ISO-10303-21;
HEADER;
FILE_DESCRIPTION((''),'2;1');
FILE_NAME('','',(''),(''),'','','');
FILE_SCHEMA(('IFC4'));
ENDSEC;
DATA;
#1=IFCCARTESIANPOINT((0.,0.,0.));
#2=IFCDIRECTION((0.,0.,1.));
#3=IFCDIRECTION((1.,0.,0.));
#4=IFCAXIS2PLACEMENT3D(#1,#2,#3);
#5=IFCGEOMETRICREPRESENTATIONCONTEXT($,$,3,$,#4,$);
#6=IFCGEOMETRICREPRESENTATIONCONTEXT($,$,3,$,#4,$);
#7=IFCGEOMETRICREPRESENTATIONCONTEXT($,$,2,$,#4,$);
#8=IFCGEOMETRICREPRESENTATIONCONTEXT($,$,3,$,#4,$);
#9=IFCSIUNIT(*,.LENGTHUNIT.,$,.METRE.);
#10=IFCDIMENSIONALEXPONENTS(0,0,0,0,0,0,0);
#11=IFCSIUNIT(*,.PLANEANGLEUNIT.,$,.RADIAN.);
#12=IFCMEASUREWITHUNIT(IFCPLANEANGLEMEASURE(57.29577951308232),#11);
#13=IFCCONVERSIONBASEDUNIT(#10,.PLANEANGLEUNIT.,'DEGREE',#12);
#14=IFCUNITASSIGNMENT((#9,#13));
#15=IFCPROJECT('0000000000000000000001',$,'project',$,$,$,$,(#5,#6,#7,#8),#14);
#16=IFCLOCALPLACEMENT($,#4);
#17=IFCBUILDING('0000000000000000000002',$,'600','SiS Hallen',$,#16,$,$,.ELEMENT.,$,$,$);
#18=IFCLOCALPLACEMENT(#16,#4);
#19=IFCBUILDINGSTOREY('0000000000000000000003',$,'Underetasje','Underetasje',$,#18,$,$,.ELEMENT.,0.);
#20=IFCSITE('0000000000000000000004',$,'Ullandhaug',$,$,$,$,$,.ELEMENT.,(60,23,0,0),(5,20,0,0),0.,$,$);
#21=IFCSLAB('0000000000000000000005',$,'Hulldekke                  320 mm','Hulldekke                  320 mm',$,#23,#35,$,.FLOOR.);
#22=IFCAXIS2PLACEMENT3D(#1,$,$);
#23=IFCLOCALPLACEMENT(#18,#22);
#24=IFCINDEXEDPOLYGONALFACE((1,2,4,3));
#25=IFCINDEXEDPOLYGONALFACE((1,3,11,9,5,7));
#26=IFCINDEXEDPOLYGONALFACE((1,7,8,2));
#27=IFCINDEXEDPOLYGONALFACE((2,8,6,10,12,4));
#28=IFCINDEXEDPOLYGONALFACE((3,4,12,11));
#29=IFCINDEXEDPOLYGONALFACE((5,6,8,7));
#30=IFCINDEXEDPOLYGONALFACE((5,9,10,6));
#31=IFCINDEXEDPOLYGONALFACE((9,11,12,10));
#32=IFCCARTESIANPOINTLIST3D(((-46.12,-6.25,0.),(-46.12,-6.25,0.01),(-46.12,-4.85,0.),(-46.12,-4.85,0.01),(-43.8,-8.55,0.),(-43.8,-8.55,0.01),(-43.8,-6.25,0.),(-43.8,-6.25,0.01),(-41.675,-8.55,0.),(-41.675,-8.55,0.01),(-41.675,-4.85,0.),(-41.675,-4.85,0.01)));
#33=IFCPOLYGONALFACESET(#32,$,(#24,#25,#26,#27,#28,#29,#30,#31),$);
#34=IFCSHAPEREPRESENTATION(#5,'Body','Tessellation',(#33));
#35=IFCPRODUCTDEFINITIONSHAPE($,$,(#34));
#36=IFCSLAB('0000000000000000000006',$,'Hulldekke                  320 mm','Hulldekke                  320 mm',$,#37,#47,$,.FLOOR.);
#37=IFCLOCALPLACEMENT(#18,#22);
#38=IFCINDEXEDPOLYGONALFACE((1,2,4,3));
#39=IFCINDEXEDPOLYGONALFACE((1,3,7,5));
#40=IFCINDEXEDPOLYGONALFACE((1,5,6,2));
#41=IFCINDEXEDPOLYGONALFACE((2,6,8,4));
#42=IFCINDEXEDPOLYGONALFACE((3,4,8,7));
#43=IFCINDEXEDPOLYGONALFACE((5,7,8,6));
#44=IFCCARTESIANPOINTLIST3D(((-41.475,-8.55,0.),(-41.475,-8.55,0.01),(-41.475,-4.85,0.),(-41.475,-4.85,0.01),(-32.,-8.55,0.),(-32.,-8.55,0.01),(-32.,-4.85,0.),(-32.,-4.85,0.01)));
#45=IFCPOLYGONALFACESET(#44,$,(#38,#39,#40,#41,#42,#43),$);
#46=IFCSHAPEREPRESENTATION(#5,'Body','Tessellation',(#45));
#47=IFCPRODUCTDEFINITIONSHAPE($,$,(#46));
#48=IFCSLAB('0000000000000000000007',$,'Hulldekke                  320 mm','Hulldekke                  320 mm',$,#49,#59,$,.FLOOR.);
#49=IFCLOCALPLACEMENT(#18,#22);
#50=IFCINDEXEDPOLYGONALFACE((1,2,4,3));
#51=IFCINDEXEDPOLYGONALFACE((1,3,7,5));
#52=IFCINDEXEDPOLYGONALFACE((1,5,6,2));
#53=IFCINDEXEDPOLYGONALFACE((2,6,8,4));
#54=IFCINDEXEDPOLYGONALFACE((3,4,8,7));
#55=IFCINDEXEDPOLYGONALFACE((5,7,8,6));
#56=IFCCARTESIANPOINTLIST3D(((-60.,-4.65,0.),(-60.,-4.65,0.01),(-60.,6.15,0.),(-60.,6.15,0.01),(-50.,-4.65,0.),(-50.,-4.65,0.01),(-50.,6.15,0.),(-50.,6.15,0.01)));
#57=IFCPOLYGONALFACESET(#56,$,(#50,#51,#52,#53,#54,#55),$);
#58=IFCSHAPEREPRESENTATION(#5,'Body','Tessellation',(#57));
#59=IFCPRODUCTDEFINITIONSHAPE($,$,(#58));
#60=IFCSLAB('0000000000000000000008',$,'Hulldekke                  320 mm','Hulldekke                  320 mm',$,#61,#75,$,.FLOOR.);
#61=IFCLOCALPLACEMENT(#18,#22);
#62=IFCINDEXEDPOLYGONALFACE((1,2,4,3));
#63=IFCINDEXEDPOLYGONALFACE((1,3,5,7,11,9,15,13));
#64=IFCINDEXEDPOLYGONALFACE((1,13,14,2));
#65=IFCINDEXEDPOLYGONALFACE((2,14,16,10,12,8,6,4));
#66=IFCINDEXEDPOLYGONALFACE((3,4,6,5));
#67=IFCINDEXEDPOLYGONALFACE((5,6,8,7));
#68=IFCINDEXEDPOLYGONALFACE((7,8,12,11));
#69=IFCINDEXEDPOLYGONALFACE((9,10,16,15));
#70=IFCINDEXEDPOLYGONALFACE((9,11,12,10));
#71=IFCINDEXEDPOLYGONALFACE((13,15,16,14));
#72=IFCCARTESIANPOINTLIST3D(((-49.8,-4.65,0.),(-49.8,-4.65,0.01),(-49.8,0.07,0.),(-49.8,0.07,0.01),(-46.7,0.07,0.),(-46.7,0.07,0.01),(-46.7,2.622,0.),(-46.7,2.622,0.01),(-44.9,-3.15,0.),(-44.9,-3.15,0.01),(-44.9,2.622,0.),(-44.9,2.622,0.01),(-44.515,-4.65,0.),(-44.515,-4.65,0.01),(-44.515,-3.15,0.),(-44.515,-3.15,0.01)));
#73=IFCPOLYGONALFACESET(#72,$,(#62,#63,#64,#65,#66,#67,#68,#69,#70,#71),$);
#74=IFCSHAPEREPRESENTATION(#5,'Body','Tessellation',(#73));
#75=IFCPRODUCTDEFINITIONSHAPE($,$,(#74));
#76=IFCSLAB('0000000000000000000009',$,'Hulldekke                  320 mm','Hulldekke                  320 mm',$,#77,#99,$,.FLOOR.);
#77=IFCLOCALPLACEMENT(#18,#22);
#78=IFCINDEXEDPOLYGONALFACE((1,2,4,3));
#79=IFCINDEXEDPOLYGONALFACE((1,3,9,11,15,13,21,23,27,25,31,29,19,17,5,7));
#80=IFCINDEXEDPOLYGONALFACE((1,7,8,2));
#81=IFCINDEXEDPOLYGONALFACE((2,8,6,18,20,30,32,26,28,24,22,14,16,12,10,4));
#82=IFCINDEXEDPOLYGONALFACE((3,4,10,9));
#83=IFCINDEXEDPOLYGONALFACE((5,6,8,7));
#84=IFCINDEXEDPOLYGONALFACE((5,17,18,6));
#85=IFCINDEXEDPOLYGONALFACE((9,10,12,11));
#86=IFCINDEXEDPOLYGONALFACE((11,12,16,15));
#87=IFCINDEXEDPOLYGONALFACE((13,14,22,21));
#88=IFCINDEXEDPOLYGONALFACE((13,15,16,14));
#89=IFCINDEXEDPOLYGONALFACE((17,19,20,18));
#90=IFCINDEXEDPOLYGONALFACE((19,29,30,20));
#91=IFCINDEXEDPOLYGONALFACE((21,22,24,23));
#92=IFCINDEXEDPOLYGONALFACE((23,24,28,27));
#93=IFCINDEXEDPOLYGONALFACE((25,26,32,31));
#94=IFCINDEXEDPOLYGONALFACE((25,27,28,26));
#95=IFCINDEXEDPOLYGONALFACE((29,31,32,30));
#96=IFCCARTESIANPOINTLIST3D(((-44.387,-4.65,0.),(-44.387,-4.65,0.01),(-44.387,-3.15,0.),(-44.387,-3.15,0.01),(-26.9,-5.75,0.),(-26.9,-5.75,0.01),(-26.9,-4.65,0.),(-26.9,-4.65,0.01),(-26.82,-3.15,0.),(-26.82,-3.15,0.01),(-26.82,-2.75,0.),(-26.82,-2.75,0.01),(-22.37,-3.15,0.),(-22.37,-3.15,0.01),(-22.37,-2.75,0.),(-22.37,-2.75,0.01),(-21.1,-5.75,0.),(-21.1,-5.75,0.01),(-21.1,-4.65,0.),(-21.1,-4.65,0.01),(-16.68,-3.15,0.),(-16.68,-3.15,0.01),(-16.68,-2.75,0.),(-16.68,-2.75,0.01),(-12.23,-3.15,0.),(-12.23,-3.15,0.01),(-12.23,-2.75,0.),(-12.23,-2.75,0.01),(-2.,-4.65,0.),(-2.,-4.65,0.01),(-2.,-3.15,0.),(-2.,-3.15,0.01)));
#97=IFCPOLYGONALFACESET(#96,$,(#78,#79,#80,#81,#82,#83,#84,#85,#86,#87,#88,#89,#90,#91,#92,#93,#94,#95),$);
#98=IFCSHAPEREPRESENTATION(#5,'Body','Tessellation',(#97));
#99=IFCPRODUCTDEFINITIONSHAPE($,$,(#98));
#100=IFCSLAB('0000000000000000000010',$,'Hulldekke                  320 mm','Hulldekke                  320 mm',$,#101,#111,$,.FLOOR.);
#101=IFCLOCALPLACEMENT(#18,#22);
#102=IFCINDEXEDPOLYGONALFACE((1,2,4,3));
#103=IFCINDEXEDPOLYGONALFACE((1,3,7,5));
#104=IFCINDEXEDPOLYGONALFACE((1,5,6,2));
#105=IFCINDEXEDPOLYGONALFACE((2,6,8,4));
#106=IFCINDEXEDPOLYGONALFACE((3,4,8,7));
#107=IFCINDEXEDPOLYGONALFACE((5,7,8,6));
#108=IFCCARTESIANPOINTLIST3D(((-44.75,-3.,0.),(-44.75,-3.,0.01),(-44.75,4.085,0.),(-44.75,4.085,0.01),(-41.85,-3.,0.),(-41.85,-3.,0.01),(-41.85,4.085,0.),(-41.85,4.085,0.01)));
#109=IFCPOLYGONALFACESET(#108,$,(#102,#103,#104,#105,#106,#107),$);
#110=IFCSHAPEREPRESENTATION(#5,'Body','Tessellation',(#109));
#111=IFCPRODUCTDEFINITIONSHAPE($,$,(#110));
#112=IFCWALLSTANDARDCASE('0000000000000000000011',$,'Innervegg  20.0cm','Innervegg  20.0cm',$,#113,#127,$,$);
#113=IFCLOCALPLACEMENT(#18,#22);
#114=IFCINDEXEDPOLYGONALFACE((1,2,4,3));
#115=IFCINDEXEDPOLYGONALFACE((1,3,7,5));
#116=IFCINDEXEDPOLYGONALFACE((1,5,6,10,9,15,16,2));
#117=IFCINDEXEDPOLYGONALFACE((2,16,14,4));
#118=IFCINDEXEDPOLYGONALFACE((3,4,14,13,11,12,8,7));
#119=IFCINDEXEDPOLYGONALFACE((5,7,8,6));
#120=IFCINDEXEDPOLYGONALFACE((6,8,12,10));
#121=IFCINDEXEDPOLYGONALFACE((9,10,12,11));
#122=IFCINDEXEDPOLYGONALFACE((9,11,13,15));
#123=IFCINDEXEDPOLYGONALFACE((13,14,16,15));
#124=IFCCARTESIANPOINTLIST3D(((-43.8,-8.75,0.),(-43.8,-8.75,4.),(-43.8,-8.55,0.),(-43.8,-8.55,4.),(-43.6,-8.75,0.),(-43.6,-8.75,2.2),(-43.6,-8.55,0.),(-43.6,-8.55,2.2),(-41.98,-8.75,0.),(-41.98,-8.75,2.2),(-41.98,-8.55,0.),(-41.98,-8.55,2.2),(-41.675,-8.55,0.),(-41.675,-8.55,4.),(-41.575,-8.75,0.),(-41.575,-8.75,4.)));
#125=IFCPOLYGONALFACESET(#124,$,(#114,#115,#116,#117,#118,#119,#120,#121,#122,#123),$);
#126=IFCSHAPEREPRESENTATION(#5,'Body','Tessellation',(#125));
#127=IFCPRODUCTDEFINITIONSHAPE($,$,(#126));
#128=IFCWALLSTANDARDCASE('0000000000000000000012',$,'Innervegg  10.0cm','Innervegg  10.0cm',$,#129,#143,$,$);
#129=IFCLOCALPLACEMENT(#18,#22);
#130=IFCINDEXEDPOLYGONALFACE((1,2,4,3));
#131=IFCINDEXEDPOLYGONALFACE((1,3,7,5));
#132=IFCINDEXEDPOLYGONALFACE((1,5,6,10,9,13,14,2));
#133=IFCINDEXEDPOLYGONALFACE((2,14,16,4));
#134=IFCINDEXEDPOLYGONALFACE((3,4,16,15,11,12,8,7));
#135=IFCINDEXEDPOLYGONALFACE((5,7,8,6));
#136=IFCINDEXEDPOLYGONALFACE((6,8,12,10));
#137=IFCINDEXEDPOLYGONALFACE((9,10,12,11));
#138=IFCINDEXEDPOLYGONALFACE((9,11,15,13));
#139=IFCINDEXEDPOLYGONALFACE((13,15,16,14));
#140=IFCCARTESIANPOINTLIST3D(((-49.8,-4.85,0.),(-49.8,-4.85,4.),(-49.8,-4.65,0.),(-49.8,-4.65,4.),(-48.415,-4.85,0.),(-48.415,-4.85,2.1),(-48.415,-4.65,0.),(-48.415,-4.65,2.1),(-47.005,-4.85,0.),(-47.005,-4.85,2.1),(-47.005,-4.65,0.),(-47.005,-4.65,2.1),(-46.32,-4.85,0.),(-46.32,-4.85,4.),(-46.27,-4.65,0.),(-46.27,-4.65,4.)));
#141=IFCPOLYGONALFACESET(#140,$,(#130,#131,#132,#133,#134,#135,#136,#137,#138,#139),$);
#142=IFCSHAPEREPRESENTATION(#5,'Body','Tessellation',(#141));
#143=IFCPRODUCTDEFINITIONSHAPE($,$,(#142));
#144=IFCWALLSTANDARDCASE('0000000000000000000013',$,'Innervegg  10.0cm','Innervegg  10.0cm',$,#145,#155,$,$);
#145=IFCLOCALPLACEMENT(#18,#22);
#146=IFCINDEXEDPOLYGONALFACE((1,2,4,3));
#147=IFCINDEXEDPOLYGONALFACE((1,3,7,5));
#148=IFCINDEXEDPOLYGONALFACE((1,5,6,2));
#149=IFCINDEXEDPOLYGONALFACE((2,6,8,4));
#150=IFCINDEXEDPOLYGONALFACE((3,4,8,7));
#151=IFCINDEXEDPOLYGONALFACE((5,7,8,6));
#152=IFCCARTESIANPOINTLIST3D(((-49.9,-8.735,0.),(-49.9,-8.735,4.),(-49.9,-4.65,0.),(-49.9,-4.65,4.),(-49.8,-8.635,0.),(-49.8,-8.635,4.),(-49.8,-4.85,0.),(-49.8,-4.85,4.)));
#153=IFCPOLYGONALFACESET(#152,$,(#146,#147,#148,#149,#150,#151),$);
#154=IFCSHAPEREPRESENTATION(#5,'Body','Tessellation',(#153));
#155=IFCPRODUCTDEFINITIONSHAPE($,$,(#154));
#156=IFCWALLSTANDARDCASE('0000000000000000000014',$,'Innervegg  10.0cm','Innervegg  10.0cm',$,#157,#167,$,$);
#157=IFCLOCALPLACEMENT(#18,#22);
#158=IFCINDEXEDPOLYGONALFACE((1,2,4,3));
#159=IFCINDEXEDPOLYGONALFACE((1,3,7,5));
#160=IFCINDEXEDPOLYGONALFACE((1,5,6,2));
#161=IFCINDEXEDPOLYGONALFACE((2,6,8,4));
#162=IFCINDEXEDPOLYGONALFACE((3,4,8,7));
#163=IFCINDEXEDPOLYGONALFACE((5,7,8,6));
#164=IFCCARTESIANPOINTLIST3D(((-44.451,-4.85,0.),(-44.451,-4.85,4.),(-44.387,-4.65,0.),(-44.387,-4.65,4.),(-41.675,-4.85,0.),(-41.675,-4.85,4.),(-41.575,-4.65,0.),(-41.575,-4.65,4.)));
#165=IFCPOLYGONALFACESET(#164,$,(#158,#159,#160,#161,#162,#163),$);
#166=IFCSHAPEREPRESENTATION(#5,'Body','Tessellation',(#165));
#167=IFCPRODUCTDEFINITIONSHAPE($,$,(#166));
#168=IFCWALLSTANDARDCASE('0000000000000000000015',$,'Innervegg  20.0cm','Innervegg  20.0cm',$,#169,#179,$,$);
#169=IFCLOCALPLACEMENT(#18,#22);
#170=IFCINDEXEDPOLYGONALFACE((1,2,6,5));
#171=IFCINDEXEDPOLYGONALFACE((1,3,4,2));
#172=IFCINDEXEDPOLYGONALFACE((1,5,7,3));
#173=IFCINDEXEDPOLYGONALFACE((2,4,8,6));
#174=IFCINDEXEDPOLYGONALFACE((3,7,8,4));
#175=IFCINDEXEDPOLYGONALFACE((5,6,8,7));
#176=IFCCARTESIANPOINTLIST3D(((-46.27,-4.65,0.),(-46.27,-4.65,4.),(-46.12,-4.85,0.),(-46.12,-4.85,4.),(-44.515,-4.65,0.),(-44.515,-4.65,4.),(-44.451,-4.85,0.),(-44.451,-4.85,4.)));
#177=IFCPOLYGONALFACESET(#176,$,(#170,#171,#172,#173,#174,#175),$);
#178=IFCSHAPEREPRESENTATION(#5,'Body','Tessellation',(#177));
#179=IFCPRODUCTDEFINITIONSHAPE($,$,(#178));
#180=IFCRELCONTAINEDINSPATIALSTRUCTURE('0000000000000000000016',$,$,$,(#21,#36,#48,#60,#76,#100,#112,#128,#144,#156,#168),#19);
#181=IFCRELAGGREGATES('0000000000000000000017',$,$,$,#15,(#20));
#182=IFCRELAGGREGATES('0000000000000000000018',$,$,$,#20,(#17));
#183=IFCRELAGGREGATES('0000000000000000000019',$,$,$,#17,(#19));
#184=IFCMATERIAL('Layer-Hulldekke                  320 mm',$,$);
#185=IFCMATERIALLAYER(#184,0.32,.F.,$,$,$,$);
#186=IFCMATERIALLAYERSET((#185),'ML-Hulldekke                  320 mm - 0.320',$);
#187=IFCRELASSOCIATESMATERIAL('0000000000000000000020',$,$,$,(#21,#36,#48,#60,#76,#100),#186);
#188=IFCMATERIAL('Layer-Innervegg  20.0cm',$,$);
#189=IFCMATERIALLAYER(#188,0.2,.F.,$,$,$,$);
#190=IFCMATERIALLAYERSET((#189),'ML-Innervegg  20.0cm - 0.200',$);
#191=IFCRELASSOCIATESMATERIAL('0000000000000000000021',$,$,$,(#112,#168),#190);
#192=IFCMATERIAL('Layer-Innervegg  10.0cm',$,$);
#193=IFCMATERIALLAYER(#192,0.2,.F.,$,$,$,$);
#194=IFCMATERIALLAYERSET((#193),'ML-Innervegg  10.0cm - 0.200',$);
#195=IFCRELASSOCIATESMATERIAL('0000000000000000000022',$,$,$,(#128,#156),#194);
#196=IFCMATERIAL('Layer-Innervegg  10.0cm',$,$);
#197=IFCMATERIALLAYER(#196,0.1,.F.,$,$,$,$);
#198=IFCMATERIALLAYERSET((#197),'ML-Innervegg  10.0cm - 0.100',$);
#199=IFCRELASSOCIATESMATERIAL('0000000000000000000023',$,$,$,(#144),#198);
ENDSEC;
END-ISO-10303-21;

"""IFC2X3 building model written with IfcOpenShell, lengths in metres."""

from ifc_helpers import new_model, entity, si_unit, converted_unit, frame, origin_with_axes, place, context, project, spatial, polyline, outline, extrude, material, layer, layer_set, layer_usage, element, save


model = new_model("IFC2X3")

# Units and contexts
context_of_model_1 = context(None, 3, world=origin_with_axes())
context_of_model_2 = context(None, 3, world=origin_with_axes())
context_of_model_3 = context(None, 2, world=origin_with_axes())
context_of_model_4 = context(None, 3, world=origin_with_axes())
ifc_project = project(units=[si_unit("LENGTHUNIT", "METRE"), converted_unit("PLANEANGLEUNIT", "DEGREE", entity("IfcPlaneAngleMeasure", 57.29577951308232), si_unit("PLANEANGLEUNIT", "RADIAN"), dimensions=[0, 0, 0, 0, 0, 0, 0])], contexts=[context_of_model_1, context_of_model_2, context_of_model_3, context_of_model_4])

# Site, building, storey
site = spatial("IfcSite", under=ifc_project, Name="Ullandhaug", CompositionType="ELEMENT", RefLatitude=(60, 23, 0, 0), RefLongitude=(5, 20, 0, 0), RefElevation=0.0)
building_placement = place(None, origin_with_axes())
building = spatial("IfcBuilding", under=site, at=building_placement, Name="600", Description="SiS Hallen", CompositionType="ELEMENT")
storey_placement = place(building_placement, origin_with_axes())
storey = spatial("IfcBuildingStorey", under=building, at=storey_placement, Name="Underetasje", Description="Underetasje", CompositionType="ELEMENT", Elevation=0.0)

# Slabs
ifc_material_1 = material(Name="Layer-Hulldekke                  320 mm")
ifc_layer_1 = layer(ifc_material_1, 0.32, ventilated=False)
ifc_layer_set_1 = layer_set([ifc_layer_1], Name="ML-Hulldekke                  320 mm - 0.320")
ifc_layer_usage_1 = layer_usage(ifc_layer_set_1, "AXIS2", "POSITIVE", 0.0)
slab_1_placement = place(storey_placement, frame((-43.8, -8.55, 0.0), z_axis=(0.0, 0.0, 1.0), x_axis=(1.0, 0.0, 0.0)))
element("IfcSlab", 1, at=slab_1_placement, inside=storey, material=ifc_layer_usage_1, Name="Hulldekke                  320 mm", Description="Hulldekke                  320 mm", PredefinedType="FLOOR", context=context_of_model_1, shape_type="SweptSolid", body=[
    extrude(outline(polyline([(0.0, 0.0), (2.125, 0.0), (2.125, 3.7), (-2.32, 3.7), (-2.32, 2.3), (0.0, 2.3), (0.0, 0.0)])), origin_with_axes(), (0.0, 0.0, 1.0), 0.01),
])
slab_2_placement = place(storey_placement, frame((-41.475, -8.55, 0.0), z_axis=(0.0, 0.0, 1.0), x_axis=(1.0, 0.0, 0.0)))
element("IfcSlab", 2, at=slab_2_placement, inside=storey, material=ifc_layer_usage_1, Name="Hulldekke                  320 mm", Description="Hulldekke                  320 mm", PredefinedType="FLOOR", context=context_of_model_1, shape_type="SweptSolid", body=[
    extrude(outline(polyline([(0.0, 0.0), (9.475, 0.0), (9.475, 3.7), (0.0, 3.7), (0.0, 0.0)])), origin_with_axes(), (0.0, 0.0, 1.0), 0.01),
])
slab_3_placement = place(storey_placement, frame((-60.0, -4.65, 0.0), z_axis=(0.0, 0.0, 1.0), x_axis=(1.0, 0.0, 0.0)))
element("IfcSlab", 3, at=slab_3_placement, inside=storey, material=ifc_layer_usage_1, Name="Hulldekke                  320 mm", Description="Hulldekke                  320 mm", PredefinedType="FLOOR", context=context_of_model_1, shape_type="SweptSolid", body=[
    extrude(outline(polyline([(0.0, 0.0), (10.0, 0.0), (10.0, 10.8), (0.0, 10.8), (0.0, 0.0)])), origin_with_axes(), (0.0, 0.0, 1.0), 0.01),
])
slab_4_placement = place(storey_placement, frame((-49.8, -4.65, 0.0), z_axis=(0.0, 0.0, 1.0), x_axis=(1.0, 0.0, 0.0)))
element("IfcSlab", 4, at=slab_4_placement, inside=storey, material=ifc_layer_usage_1, Name="Hulldekke                  320 mm", Description="Hulldekke                  320 mm", PredefinedType="FLOOR", context=context_of_model_1, shape_type="SweptSolid", body=[
    extrude(outline(polyline([(0.0, 0.0), (5.285, 0.0), (5.285, 1.5), (4.9, 1.5), (4.9, 7.272), (3.1, 7.272), (3.1, 4.72), (0.0, 4.72), (0.0, 0.0)])), origin_with_axes(), (0.0, 0.0, 1.0), 0.01),
])
slab_5_placement = place(storey_placement, frame((-44.387, -4.65, 0.0), z_axis=(0.0, 0.0, 1.0), x_axis=(1.0, 0.0, 0.0)))
element("IfcSlab", 5, at=slab_5_placement, inside=storey, material=ifc_layer_usage_1, Name="Hulldekke                  320 mm", Description="Hulldekke                  320 mm", PredefinedType="FLOOR", context=context_of_model_1, shape_type="SweptSolid", body=[
    extrude(outline(polyline([(0.0, 0.0), (17.487, 0.0), (17.487, 1.1), (23.287, 1.1), (23.287, 0.0), (42.387, 0.0), (42.387, -1.5), (32.157, -1.5), (32.157, -1.9), (27.707, -1.9), (27.707, -1.5), (22.017, -1.5), (22.017, -1.9), (17.567, -1.9), (17.567, -1.5), (0.0, -1.5), (0.0, 0.0)])), frame((0.0, 0.0, 0.0), z_axis=(0.0, 0.0, -1.0), x_axis=(1.0, 0.0, 0.0)), (0.0, 0.0, -1.0), 0.01),
])
slab_6_placement = place(storey_placement, frame((-44.75, -3.0, 0.0), z_axis=(0.0, 0.0, 1.0), x_axis=(1.0, 0.0, 0.0)))
element("IfcSlab", 6, at=slab_6_placement, inside=storey, material=ifc_layer_usage_1, Name="Hulldekke                  320 mm", Description="Hulldekke                  320 mm", PredefinedType="FLOOR", context=context_of_model_1, shape_type="SweptSolid", body=[
    extrude(outline(polyline([(0.0, 0.0), (2.9, 0.0), (2.9, 7.085), (0.0, 7.085), (0.0, 0.0)])), origin_with_axes(), (0.0, 0.0, 1.0), 0.01),
])

# Walls, openings
ifc_material_2 = material(Name="Layer-Innervegg  20.0cm")
ifc_layer_2 = layer(ifc_material_2, 0.2, ventilated=False)
ifc_layer_set_2 = layer_set([ifc_layer_2], Name="ML-Innervegg  20.0cm - 0.200")
ifc_layer_usage_2 = layer_usage(ifc_layer_set_2, "AXIS2", "POSITIVE", 0.0)
wall_1_placement = place(storey_placement, frame((-41.675, -8.55, 0.0), z_axis=(0.0, 0.0, 1.0), x_axis=(-1.0, 0.0, 0.0)))
wall_1 = element("IfcWallStandardCase", 7, at=wall_1_placement, inside=storey, material=ifc_layer_usage_2, Name="Innervegg  20.0cm", Description="Innervegg  20.0cm", context=context_of_model_1, shape_type="SweptSolid", body=[
    extrude(outline(polyline([(0.0, 0.0), (2.125, 0.0), (2.125, 0.2), (-0.1, 0.2), (0.0, 0.0)])), frame((0.0, 0.0, 0.0), z_axis=(0.0, 0.0, 1.0), x_axis=(1.0, 0.0, 0.0)), (0.0, 0.0, 1.0), 4.0),
])
opening_1_placement = place(wall_1_placement, frame((0.305, 0.2, 0.0), z_axis=(0.0, 0.0, 1.0), x_axis=(1.0, 0.0, 0.0)))
element("IfcOpeningElement", 8, at=opening_1_placement, cuts=wall_1, context=context_of_model_1, shape_type="SweptSolid", body=[
    extrude(outline(polyline([(0.0, 0.0), (2.2, 0.0), (2.2, 1.62), (0.0, 1.62), (0.0, 0.0)])), frame((0.0, 0.0, 0.0), z_axis=(0.0, 1.0, 0.0), x_axis=(0.0, 0.0, 1.0)), (0.0, 0.0, -1.0), 0.2),
])
ifc_material_3 = material(Name="Layer-Innervegg  10.0cm")
ifc_layer_3 = layer(ifc_material_3, 0.2, ventilated=False)
ifc_layer_set_3 = layer_set([ifc_layer_3], Name="ML-Innervegg  10.0cm - 0.200")
ifc_layer_usage_3 = layer_usage(ifc_layer_set_3, "AXIS2", "POSITIVE", 0.0)
wall_2_placement = place(storey_placement, frame((-46.27, -4.65, 0.0), z_axis=(0.0, 0.0, 1.0), x_axis=(-1.0, 0.0, 0.0)))
wall_2 = element("IfcWallStandardCase", 9, at=wall_2_placement, inside=storey, material=ifc_layer_usage_3, Name="Innervegg  10.0cm", Description="Innervegg  10.0cm", context=context_of_model_1, shape_type="SweptSolid", body=[
    extrude(outline(polyline([(0.0, 0.0), (3.53, 0.0), (3.53, 0.2), (0.05, 0.2), (0.0, 0.0)])), frame((0.0, 0.0, 0.0), z_axis=(0.0, 0.0, 1.0), x_axis=(1.0, 0.0, 0.0)), (0.0, 0.0, 1.0), 4.0),
])
opening_2_placement = place(wall_2_placement, frame((0.735, 0.2, 0.0), z_axis=(0.0, 0.0, 1.0), x_axis=(1.0, 0.0, 0.0)))
element("IfcOpeningElement", 10, at=opening_2_placement, cuts=wall_2, context=context_of_model_1, shape_type="SweptSolid", body=[
    extrude(outline(polyline([(0.0, 0.0), (2.1, 0.0), (2.1, 1.41), (0.0, 1.41), (0.0, 0.0)])), frame((0.0, 0.0, 0.0), z_axis=(0.0, 1.0, 0.0), x_axis=(0.0, 0.0, 1.0)), (0.0, 0.0, -1.0), 0.2),
])

# Walls
ifc_material_4 = material(Name="Layer-Innervegg  10.0cm")
ifc_layer_4 = layer(ifc_material_4, 0.1, ventilated=False)
ifc_layer_set_4 = layer_set([ifc_layer_4], Name="ML-Innervegg  10.0cm - 0.100")
ifc_layer_usage_4 = layer_usage(ifc_layer_set_4, "AXIS2", "POSITIVE", 0.0)
wall_3_placement = place(storey_placement, frame((-49.9, -4.65, 0.0), z_axis=(0.0, 0.0, 1.0), x_axis=(0.0, -1.0, 0.0)))
element("IfcWallStandardCase", 11, at=wall_3_placement, inside=storey, material=ifc_layer_usage_4, Name="Innervegg  10.0cm", Description="Innervegg  10.0cm", context=context_of_model_1, shape_type="SweptSolid", body=[
    extrude(outline(polyline([(0.0, 0.0), (4.085, 0.0), (3.985, 0.1), (0.2, 0.1), (0.0, 0.0)])), frame((0.0, 0.0, 0.0), z_axis=(0.0, 0.0, 1.0), x_axis=(1.0, 0.0, 0.0)), (0.0, 0.0, 1.0), 4.0),
])
wall_4_placement = place(storey_placement, frame((-41.575, -4.65, 0.0), z_axis=(0.0, 0.0, 1.0), x_axis=(-1.0, 0.0, 0.0)))
element("IfcWallStandardCase", 12, at=wall_4_placement, inside=storey, material=ifc_layer_usage_3, Name="Innervegg  10.0cm", Description="Innervegg  10.0cm", context=context_of_model_1, shape_type="SweptSolid", body=[
    extrude(outline(polyline([(0.0, 0.0), (2.812, 0.0), (2.876, 0.2), (0.1, 0.2), (0.0, 0.0)])), frame((0.0, 0.0, 0.0), z_axis=(0.0, 0.0, 1.0), x_axis=(1.0, 0.0, 0.0)), (0.0, 0.0, 1.0), 4.0),
])
wall_5_placement = place(storey_placement, frame((-44.515, -4.65, 0.0), z_axis=(0.0, 0.0, 1.0), x_axis=(-1.0, 0.0, 0.0)))
element("IfcWallStandardCase", 13, at=wall_5_placement, inside=storey, material=ifc_layer_usage_2, Name="Innervegg  20.0cm", Description="Innervegg  20.0cm", context=context_of_model_1, shape_type="SweptSolid", body=[
    extrude(outline(polyline([(0.0, 0.0), (1.755, 0.0), (1.605, 0.2), (-0.064, 0.2), (0.0, 0.0)])), frame((0.0, 0.0, 0.0), z_axis=(0.0, 0.0, 1.0), x_axis=(1.0, 0.0, 0.0)), (0.0, 0.0, 1.0), 4.0),
])

save(model, "model.ifc")
